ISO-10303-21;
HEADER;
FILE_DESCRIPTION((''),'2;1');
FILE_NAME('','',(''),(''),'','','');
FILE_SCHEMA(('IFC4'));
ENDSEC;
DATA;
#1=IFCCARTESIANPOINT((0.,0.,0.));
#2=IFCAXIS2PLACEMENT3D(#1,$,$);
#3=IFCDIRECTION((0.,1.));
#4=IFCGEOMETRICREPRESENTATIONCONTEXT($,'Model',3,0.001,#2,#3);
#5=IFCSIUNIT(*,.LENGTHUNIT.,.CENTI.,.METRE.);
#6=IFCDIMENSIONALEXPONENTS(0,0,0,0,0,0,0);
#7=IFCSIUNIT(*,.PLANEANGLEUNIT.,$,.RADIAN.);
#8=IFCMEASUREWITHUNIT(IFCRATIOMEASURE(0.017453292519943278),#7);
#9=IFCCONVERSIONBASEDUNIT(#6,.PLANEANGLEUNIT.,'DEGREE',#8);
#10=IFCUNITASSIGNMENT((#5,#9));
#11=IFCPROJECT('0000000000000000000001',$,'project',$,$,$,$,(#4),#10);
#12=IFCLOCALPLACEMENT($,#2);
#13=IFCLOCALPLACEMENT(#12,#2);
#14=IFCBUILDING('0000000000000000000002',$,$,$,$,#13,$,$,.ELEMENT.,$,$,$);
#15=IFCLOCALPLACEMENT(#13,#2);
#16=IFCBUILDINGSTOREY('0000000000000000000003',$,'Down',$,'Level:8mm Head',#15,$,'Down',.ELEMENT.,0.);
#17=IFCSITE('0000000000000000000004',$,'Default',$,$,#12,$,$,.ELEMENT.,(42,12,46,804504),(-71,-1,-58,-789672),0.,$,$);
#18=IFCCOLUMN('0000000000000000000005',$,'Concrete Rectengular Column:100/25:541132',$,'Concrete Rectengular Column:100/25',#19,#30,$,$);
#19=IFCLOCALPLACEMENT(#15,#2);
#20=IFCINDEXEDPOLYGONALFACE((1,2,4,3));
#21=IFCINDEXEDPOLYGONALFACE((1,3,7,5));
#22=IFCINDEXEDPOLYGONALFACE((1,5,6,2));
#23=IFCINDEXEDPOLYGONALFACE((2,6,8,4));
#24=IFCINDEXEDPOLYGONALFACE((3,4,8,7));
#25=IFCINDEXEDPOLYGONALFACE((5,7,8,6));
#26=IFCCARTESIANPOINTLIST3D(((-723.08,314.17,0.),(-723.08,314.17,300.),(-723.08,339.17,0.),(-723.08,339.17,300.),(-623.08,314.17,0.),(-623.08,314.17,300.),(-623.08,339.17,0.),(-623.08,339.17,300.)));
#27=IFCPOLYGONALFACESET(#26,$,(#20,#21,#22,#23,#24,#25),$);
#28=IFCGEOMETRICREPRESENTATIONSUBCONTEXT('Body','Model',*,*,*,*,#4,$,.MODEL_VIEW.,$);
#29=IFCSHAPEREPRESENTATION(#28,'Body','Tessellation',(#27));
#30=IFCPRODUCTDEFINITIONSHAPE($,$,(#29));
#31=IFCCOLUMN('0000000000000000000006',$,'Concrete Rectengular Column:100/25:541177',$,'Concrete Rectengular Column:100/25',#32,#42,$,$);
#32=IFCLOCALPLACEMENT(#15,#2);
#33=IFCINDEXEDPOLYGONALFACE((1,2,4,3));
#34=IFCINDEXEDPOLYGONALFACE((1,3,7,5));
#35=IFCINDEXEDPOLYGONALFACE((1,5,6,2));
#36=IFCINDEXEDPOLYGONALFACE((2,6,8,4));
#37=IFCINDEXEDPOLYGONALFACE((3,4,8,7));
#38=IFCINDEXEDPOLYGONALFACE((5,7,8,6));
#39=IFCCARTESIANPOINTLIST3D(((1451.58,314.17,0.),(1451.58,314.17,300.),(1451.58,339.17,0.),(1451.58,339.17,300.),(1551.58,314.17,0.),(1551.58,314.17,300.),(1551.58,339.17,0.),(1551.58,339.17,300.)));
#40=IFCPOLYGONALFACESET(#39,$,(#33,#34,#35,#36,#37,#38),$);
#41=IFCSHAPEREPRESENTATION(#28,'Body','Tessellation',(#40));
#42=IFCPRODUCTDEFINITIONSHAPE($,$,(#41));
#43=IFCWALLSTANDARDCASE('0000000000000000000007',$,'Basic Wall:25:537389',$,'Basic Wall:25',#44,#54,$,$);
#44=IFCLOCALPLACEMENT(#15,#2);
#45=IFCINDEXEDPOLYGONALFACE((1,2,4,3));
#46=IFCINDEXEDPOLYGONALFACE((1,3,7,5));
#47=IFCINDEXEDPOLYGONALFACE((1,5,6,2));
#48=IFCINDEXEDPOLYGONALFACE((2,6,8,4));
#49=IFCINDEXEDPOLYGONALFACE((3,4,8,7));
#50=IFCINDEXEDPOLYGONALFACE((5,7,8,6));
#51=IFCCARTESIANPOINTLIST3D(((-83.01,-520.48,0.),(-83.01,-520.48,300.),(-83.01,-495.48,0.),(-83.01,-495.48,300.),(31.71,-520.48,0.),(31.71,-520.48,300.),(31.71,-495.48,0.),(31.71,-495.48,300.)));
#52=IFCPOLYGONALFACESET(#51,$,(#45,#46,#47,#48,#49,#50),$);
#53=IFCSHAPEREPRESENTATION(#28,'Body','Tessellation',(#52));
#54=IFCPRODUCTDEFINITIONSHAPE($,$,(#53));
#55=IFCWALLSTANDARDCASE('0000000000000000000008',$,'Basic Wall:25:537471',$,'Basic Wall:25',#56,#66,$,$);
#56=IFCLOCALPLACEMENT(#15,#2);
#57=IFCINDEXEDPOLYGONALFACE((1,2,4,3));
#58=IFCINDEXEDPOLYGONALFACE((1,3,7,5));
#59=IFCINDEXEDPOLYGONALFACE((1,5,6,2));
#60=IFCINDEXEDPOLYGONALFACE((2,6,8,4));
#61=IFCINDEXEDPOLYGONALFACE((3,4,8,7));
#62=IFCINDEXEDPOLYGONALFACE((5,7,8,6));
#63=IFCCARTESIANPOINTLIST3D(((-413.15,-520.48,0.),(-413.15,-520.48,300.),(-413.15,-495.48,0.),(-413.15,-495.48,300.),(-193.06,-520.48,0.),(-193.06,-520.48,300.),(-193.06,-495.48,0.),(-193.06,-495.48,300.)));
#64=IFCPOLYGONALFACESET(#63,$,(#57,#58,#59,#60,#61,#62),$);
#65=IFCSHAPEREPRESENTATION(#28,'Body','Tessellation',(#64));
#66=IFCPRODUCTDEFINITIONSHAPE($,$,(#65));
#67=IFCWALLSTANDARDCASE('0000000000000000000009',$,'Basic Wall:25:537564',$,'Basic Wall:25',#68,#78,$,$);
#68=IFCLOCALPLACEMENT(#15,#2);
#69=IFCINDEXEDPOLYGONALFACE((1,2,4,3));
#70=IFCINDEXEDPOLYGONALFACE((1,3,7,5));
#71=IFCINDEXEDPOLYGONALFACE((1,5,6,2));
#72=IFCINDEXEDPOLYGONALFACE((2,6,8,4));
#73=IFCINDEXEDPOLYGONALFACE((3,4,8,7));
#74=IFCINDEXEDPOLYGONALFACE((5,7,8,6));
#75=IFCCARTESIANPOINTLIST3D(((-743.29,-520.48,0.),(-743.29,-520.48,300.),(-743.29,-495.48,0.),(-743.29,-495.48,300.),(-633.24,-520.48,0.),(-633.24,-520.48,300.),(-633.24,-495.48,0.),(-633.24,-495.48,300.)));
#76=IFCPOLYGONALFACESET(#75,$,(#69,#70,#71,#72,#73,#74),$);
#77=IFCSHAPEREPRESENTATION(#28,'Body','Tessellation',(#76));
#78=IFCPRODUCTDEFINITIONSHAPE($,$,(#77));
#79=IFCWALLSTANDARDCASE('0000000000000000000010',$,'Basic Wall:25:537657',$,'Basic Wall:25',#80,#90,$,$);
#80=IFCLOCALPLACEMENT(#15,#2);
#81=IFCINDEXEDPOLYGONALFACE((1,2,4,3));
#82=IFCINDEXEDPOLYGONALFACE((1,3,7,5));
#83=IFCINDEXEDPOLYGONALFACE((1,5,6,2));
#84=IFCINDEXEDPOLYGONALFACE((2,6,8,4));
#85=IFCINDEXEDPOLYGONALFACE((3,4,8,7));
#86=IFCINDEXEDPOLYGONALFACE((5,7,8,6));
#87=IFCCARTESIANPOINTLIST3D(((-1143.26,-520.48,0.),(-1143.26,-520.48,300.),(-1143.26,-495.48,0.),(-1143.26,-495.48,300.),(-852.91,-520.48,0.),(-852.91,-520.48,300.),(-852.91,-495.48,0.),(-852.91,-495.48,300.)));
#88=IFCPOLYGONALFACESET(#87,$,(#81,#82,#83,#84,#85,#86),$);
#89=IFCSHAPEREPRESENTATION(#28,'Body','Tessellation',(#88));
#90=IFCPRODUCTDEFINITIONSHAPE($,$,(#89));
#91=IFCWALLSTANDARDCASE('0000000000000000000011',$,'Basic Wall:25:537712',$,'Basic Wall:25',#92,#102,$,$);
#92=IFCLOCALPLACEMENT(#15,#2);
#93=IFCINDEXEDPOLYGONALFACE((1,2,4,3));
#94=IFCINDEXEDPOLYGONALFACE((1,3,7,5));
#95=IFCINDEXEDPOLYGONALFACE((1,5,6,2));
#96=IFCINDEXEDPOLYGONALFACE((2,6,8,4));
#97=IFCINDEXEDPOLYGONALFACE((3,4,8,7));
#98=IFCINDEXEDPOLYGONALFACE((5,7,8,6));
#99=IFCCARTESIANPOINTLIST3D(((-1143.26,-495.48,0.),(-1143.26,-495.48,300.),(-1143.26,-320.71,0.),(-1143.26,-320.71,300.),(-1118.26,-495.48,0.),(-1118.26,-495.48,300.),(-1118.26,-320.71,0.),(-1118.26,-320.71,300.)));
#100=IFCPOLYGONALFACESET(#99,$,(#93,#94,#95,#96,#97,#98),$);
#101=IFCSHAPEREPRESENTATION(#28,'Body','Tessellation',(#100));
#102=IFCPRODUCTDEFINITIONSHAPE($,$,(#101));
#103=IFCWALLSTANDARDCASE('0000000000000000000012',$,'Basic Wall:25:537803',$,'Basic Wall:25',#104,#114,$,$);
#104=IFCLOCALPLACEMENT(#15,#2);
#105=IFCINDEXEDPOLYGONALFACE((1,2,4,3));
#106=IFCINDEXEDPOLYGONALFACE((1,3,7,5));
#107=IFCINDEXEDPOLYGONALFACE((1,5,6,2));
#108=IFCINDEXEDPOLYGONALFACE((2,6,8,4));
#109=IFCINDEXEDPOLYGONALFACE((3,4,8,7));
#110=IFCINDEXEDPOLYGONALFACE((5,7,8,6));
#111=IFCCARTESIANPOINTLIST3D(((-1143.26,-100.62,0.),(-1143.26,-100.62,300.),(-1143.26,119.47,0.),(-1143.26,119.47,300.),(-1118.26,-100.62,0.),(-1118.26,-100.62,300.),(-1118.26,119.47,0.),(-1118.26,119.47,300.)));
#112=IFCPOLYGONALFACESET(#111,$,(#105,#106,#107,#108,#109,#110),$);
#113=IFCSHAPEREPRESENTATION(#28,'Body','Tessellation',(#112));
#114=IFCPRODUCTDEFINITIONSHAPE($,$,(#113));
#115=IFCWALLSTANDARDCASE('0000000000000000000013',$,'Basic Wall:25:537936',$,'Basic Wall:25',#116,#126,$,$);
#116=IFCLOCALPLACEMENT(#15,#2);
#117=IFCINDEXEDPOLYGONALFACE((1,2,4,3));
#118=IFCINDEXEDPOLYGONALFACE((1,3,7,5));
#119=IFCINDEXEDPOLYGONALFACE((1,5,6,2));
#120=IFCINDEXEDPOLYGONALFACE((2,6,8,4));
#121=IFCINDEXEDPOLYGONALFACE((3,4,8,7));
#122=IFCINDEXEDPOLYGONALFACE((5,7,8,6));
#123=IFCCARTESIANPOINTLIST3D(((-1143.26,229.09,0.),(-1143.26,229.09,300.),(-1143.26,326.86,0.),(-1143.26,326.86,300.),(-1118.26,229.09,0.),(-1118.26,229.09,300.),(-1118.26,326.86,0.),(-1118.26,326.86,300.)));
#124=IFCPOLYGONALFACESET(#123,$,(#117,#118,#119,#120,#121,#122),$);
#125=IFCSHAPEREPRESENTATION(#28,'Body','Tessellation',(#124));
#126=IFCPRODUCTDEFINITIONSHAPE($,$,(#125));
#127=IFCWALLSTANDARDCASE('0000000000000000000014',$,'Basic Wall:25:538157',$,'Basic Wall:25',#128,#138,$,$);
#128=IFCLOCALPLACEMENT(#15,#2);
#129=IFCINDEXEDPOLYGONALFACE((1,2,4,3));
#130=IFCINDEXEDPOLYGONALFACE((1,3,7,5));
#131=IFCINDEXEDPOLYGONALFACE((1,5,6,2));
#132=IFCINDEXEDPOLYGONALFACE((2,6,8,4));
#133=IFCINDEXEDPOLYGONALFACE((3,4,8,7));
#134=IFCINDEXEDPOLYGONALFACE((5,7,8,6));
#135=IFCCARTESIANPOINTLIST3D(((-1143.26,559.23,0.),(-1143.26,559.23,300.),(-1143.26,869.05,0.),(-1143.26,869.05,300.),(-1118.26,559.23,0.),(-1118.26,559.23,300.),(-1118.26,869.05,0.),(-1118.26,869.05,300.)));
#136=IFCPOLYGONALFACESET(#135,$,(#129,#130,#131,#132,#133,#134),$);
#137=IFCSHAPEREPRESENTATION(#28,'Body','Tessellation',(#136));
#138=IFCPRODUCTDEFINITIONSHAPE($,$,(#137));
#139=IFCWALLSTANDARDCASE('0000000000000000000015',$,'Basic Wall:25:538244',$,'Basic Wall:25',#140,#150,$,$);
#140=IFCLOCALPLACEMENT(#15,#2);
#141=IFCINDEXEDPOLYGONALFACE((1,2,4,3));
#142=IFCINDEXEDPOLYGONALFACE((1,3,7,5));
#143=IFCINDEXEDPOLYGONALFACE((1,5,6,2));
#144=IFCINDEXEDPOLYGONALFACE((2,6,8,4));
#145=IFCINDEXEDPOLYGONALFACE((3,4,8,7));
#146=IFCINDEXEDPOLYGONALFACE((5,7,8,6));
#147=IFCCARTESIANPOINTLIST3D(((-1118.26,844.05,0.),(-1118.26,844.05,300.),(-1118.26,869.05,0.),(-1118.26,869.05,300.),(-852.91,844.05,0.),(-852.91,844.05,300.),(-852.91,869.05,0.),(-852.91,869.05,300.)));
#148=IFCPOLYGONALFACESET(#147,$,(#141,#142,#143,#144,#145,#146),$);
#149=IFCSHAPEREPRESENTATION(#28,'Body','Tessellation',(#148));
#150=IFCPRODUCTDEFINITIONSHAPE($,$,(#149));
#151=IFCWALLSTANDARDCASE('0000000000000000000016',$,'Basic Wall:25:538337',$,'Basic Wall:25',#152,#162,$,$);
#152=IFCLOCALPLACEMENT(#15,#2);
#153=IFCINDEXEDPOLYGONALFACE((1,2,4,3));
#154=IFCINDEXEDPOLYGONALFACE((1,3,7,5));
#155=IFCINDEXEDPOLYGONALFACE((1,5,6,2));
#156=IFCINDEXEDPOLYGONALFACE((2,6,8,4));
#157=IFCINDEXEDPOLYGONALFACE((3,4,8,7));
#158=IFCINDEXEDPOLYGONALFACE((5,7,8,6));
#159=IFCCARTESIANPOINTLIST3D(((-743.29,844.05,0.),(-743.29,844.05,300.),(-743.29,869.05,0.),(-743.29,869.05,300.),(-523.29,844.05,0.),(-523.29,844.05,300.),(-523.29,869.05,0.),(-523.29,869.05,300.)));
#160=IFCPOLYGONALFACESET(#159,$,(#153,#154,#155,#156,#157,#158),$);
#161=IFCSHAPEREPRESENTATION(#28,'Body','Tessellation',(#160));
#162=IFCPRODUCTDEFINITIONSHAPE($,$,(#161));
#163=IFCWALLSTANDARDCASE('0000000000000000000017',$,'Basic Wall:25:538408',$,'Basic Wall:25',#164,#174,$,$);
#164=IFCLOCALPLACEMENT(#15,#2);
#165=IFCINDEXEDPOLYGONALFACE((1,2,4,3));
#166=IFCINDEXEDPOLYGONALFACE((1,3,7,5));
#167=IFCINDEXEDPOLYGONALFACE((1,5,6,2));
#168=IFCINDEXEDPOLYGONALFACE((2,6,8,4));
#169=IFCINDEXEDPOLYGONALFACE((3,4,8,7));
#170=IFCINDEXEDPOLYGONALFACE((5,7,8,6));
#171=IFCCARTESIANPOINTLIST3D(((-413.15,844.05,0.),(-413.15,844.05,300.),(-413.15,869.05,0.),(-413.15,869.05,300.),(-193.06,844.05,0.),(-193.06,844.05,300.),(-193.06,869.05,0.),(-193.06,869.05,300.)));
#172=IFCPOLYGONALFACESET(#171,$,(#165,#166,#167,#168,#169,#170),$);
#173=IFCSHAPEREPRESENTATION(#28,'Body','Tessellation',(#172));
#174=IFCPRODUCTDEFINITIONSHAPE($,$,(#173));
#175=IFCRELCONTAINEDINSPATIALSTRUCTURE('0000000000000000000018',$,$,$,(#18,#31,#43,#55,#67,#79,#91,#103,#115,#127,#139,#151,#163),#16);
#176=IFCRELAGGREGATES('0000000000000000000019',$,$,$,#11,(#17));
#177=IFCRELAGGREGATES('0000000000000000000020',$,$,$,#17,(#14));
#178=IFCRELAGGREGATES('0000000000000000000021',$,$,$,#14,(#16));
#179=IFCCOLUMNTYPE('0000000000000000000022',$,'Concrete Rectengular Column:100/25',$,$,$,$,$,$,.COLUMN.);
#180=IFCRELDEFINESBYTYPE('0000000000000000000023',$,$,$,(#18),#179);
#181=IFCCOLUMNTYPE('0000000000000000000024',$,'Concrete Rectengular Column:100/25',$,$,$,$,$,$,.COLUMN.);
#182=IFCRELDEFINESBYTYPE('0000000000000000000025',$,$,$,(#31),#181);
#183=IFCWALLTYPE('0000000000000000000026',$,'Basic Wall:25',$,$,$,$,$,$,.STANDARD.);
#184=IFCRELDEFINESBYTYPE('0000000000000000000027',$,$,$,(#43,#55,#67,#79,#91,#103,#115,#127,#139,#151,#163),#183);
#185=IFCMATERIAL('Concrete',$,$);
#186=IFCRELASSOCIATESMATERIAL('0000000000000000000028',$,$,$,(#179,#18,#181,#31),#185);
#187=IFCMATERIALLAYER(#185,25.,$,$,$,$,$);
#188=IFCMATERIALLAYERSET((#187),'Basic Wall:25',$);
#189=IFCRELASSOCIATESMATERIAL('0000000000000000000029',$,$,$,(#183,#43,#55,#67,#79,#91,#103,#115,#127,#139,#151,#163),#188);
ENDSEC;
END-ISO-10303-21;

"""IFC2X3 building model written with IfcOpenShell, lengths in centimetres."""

from ifc_helpers import new_model, entity, si_unit, converted_unit, direction, frame, frame_2d, origin, place, context, subcontext, project, spatial, rectangle, extrude, source, transform, mapped, material, layer, layer_set, layer_usage, type_object, type_shapes, element, save


model = new_model("IFC2X3")

# Units and contexts
model_context = context("Model", 3, precision=0.001, world=origin(), true_north=direction((0.0, 1.0)))
body_context = subcontext(model_context, "Body", "Model", "MODEL_VIEW")
ifc_project = project(units=[si_unit("LENGTHUNIT", "METRE", prefix="CENTI"), converted_unit("PLANEANGLEUNIT", "DEGREE", entity("IfcRatioMeasure", 0.017453292519943278), si_unit("PLANEANGLEUNIT", "RADIAN"), dimensions=[0, 0, 0, 0, 0, 0, 0])], contexts=[model_context])

# Site, building, storey
site_placement = place(None, origin())
site = spatial("IfcSite", under=ifc_project, at=site_placement, Name="Default", CompositionType="ELEMENT", RefLatitude=(42, 12, 46, 804504), RefLongitude=(-71, -1, -58, -789672), RefElevation=0.0)
building_placement = place(site_placement, origin())
building = spatial("IfcBuilding", under=site, at=building_placement, CompositionType="ELEMENT")
storey_placement = place(building_placement, origin())
storey = spatial("IfcBuildingStorey", under=building, at=storey_placement, Name="Down", ObjectType="Level:8mm Head", LongName="Down", CompositionType="ELEMENT", Elevation=0.0)

# Columns
ifc_material = material(Name="Concrete")
column_type_1 = type_object("IfcColumnType", Name="Concrete Rectengular Column:100/25", PredefinedType="COLUMN", material=ifc_material)
shared_shape_1 = source(origin(), body_context, "Body", "SweptSolid", [
    extrude(rectangle(XDim=25.0, YDim=100.0, at=frame_2d((0.0, 0.0), x_axis=(1.0, 0.0))), frame((-673.08, 326.67, 0.0), z_axis=(0.0, 0.0, 1.0), x_axis=(0.0, -1.0, 0.0)), (0.0, 0.0, 1.0), 300.0),
])
type_shapes(column_type_1, [shared_shape_1])
column_1_placement = place(storey_placement, origin())
element("IfcColumn", 1, at=column_1_placement, inside=storey, type_object=column_type_1, material=ifc_material, Name="Concrete Rectengular Column:100/25:541132", ObjectType="Concrete Rectengular Column:100/25", context=body_context, shape_type="MappedRepresentation", body=[
    mapped(shared_shape_1, transform((0.0, 0.0, 0.0), scale=1.0)),
])
column_type_2 = type_object("IfcColumnType", Name="Concrete Rectengular Column:100/25", PredefinedType="COLUMN", material=ifc_material)
shared_shape_2 = source(origin(), body_context, "Body", "SweptSolid", [
    extrude(rectangle(XDim=25.0, YDim=100.0, at=frame_2d((0.0, 0.0), x_axis=(1.0, 0.0))), frame((1501.58, 326.67, 0.0), z_axis=(0.0, 0.0, 1.0), x_axis=(0.0, -1.0, 0.0)), (0.0, 0.0, 1.0), 300.0),
])
type_shapes(column_type_2, [shared_shape_2])
column_2_placement = place(storey_placement, origin())
element("IfcColumn", 2, at=column_2_placement, inside=storey, type_object=column_type_2, material=ifc_material, Name="Concrete Rectengular Column:100/25:541177", ObjectType="Concrete Rectengular Column:100/25", context=body_context, shape_type="MappedRepresentation", body=[
    mapped(shared_shape_2, transform((0.0, 0.0, 0.0), scale=1.0)),
])

# Walls
ifc_layer = layer(ifc_material, 25.0)
ifc_layer_set = layer_set([ifc_layer], Name="Basic Wall:25")
ifc_layer_usage_1 = layer_usage(ifc_layer_set, "AXIS2", "NEGATIVE", 12.5)
wall_type = type_object("IfcWallType", Name="Basic Wall:25", PredefinedType="STANDARD", material=ifc_layer_set)
wall_1_placement = place(storey_placement, frame((31.71, -507.98, 0.0), z_axis=(0.0, 0.0, 1.0), x_axis=(-1.0, 0.0, 0.0)))
element("IfcWallStandardCase", 3, at=wall_1_placement, inside=storey, type_object=wall_type, material=ifc_layer_usage_1, Name="Basic Wall:25:537389", ObjectType="Basic Wall:25", context=body_context, shape_type="SweptSolid", body=[
    extrude(rectangle(XDim=114.73, YDim=25.0, at=frame_2d((57.36, 0.0), x_axis=(-1.0, 0.0))), origin(), (0.0, 0.0, 1.0), 300.0),
])
ifc_layer_usage_2 = layer_usage(ifc_layer_set, "AXIS2", "NEGATIVE", 12.5)
wall_2_placement = place(storey_placement, frame((-193.06, -507.98, 0.0), z_axis=(0.0, 0.0, 1.0), x_axis=(-1.0, 0.0, 0.0)))
element("IfcWallStandardCase", 4, at=wall_2_placement, inside=storey, type_object=wall_type, material=ifc_layer_usage_2, Name="Basic Wall:25:537471", ObjectType="Basic Wall:25", context=body_context, shape_type="SweptSolid", body=[
    extrude(rectangle(XDim=220.09, YDim=25.0, at=frame_2d((110.05, 0.0), x_axis=(-1.0, 0.0))), origin(), (0.0, 0.0, 1.0), 300.0),
])
ifc_layer_usage_3 = layer_usage(ifc_layer_set, "AXIS2", "NEGATIVE", 12.5)
wall_3_placement = place(storey_placement, frame((-633.24, -507.98, 0.0), z_axis=(0.0, 0.0, 1.0), x_axis=(-1.0, 0.0, 0.0)))
element("IfcWallStandardCase", 5, at=wall_3_placement, inside=storey, type_object=wall_type, material=ifc_layer_usage_3, Name="Basic Wall:25:537564", ObjectType="Basic Wall:25", context=body_context, shape_type="SweptSolid", body=[
    extrude(rectangle(XDim=110.05, YDim=25.0, at=frame_2d((55.02, 0.0), x_axis=(-1.0, 0.0))), origin(), (0.0, 0.0, 1.0), 300.0),
])
ifc_layer_usage_4 = layer_usage(ifc_layer_set, "AXIS2", "NEGATIVE", 12.5)
wall_4_placement = place(storey_placement, frame((-852.91, -507.98, 0.0), z_axis=(0.0, 0.0, 1.0), x_axis=(-1.0, 0.0, 0.0)))
element("IfcWallStandardCase", 6, at=wall_4_placement, inside=storey, type_object=wall_type, material=ifc_layer_usage_4, Name="Basic Wall:25:537657", ObjectType="Basic Wall:25", context=body_context, shape_type="SweptSolid", body=[
    extrude(rectangle(XDim=290.35, YDim=25.0, at=frame_2d((145.17, 0.0), x_axis=(-1.0, 0.0))), origin(), (0.0, 0.0, 1.0), 300.0),
])
ifc_layer_usage_5 = layer_usage(ifc_layer_set, "AXIS2", "NEGATIVE", 12.5)
wall_5_placement = place(storey_placement, frame((-1130.76, -495.48, 0.0), z_axis=(0.0, 0.0, 1.0), x_axis=(0.0, 1.0, 0.0)))
element("IfcWallStandardCase", 7, at=wall_5_placement, inside=storey, type_object=wall_type, material=ifc_layer_usage_5, Name="Basic Wall:25:537712", ObjectType="Basic Wall:25", context=body_context, shape_type="SweptSolid", body=[
    extrude(rectangle(XDim=174.77, YDim=25.0, at=frame_2d((87.39, 0.0), x_axis=(-1.0, 0.0))), origin(), (0.0, 0.0, 1.0), 300.0),
])
ifc_layer_usage_6 = layer_usage(ifc_layer_set, "AXIS2", "NEGATIVE", 12.5)
wall_6_placement = place(storey_placement, frame((-1130.76, -100.62, 0.0), z_axis=(0.0, 0.0, 1.0), x_axis=(0.0, 1.0, 0.0)))
element("IfcWallStandardCase", 8, at=wall_6_placement, inside=storey, type_object=wall_type, material=ifc_layer_usage_6, Name="Basic Wall:25:537803", ObjectType="Basic Wall:25", context=body_context, shape_type="SweptSolid", body=[
    extrude(rectangle(XDim=220.09, YDim=25.0, at=frame_2d((110.05, 0.0), x_axis=(-1.0, 0.0))), origin(), (0.0, 0.0, 1.0), 300.0),
])
ifc_layer_usage_7 = layer_usage(ifc_layer_set, "AXIS2", "NEGATIVE", 12.5)
wall_7_placement = place(storey_placement, frame((-1130.76, 229.09, 0.0), z_axis=(0.0, 0.0, 1.0), x_axis=(0.0, 1.0, 0.0)))
element("IfcWallStandardCase", 9, at=wall_7_placement, inside=storey, type_object=wall_type, material=ifc_layer_usage_7, Name="Basic Wall:25:537936", ObjectType="Basic Wall:25", context=body_context, shape_type="SweptSolid", body=[
    extrude(rectangle(XDim=97.77, YDim=25.0, at=frame_2d((48.89, 0.0), x_axis=(-1.0, 0.0))), origin(), (0.0, 0.0, 1.0), 300.0),
])
ifc_layer_usage_8 = layer_usage(ifc_layer_set, "AXIS2", "NEGATIVE", 12.5)
wall_8_placement = place(storey_placement, frame((-1130.76, 559.23, 0.0), z_axis=(0.0, 0.0, 1.0), x_axis=(0.0, 1.0, 0.0)))
element("IfcWallStandardCase", 10, at=wall_8_placement, inside=storey, type_object=wall_type, material=ifc_layer_usage_8, Name="Basic Wall:25:538157", ObjectType="Basic Wall:25", context=body_context, shape_type="SweptSolid", body=[
    extrude(rectangle(XDim=309.82, YDim=25.0, at=frame_2d((154.91, 0.0), x_axis=(-1.0, 0.0))), origin(), (0.0, 0.0, 1.0), 300.0),
])
ifc_layer_usage_9 = layer_usage(ifc_layer_set, "AXIS2", "NEGATIVE", 12.5)
wall_9_placement = place(storey_placement, frame((-1118.26, 856.55, 0.0)))
element("IfcWallStandardCase", 11, at=wall_9_placement, inside=storey, type_object=wall_type, material=ifc_layer_usage_9, Name="Basic Wall:25:538244", ObjectType="Basic Wall:25", context=body_context, shape_type="SweptSolid", body=[
    extrude(rectangle(XDim=265.35, YDim=25.0, at=frame_2d((132.67, 0.0), x_axis=(-1.0, 0.0))), origin(), (0.0, 0.0, 1.0), 300.0),
])
ifc_layer_usage_10 = layer_usage(ifc_layer_set, "AXIS2", "NEGATIVE", 12.5)
wall_10_placement = place(storey_placement, frame((-743.29, 856.55, 0.0)))
element("IfcWallStandardCase", 12, at=wall_10_placement, inside=storey, type_object=wall_type, material=ifc_layer_usage_10, Name="Basic Wall:25:538337", ObjectType="Basic Wall:25", context=body_context, shape_type="SweptSolid", body=[
    extrude(rectangle(XDim=220.0, YDim=25.0, at=frame_2d((110.0, 0.0), x_axis=(-1.0, 0.0))), origin(), (0.0, 0.0, 1.0), 300.0),
])
ifc_layer_usage_11 = layer_usage(ifc_layer_set, "AXIS2", "NEGATIVE", 12.5)
wall_11_placement = place(storey_placement, frame((-413.15, 856.55, 0.0)))
element("IfcWallStandardCase", 13, at=wall_11_placement, inside=storey, type_object=wall_type, material=ifc_layer_usage_11, Name="Basic Wall:25:538408", ObjectType="Basic Wall:25", context=body_context, shape_type="SweptSolid", body=[
    extrude(rectangle(XDim=220.09, YDim=25.0, at=frame_2d((110.05, 0.0), x_axis=(-1.0, 0.0))), origin(), (0.0, 0.0, 1.0), 300.0),
])

save(model, "model.ifc")
